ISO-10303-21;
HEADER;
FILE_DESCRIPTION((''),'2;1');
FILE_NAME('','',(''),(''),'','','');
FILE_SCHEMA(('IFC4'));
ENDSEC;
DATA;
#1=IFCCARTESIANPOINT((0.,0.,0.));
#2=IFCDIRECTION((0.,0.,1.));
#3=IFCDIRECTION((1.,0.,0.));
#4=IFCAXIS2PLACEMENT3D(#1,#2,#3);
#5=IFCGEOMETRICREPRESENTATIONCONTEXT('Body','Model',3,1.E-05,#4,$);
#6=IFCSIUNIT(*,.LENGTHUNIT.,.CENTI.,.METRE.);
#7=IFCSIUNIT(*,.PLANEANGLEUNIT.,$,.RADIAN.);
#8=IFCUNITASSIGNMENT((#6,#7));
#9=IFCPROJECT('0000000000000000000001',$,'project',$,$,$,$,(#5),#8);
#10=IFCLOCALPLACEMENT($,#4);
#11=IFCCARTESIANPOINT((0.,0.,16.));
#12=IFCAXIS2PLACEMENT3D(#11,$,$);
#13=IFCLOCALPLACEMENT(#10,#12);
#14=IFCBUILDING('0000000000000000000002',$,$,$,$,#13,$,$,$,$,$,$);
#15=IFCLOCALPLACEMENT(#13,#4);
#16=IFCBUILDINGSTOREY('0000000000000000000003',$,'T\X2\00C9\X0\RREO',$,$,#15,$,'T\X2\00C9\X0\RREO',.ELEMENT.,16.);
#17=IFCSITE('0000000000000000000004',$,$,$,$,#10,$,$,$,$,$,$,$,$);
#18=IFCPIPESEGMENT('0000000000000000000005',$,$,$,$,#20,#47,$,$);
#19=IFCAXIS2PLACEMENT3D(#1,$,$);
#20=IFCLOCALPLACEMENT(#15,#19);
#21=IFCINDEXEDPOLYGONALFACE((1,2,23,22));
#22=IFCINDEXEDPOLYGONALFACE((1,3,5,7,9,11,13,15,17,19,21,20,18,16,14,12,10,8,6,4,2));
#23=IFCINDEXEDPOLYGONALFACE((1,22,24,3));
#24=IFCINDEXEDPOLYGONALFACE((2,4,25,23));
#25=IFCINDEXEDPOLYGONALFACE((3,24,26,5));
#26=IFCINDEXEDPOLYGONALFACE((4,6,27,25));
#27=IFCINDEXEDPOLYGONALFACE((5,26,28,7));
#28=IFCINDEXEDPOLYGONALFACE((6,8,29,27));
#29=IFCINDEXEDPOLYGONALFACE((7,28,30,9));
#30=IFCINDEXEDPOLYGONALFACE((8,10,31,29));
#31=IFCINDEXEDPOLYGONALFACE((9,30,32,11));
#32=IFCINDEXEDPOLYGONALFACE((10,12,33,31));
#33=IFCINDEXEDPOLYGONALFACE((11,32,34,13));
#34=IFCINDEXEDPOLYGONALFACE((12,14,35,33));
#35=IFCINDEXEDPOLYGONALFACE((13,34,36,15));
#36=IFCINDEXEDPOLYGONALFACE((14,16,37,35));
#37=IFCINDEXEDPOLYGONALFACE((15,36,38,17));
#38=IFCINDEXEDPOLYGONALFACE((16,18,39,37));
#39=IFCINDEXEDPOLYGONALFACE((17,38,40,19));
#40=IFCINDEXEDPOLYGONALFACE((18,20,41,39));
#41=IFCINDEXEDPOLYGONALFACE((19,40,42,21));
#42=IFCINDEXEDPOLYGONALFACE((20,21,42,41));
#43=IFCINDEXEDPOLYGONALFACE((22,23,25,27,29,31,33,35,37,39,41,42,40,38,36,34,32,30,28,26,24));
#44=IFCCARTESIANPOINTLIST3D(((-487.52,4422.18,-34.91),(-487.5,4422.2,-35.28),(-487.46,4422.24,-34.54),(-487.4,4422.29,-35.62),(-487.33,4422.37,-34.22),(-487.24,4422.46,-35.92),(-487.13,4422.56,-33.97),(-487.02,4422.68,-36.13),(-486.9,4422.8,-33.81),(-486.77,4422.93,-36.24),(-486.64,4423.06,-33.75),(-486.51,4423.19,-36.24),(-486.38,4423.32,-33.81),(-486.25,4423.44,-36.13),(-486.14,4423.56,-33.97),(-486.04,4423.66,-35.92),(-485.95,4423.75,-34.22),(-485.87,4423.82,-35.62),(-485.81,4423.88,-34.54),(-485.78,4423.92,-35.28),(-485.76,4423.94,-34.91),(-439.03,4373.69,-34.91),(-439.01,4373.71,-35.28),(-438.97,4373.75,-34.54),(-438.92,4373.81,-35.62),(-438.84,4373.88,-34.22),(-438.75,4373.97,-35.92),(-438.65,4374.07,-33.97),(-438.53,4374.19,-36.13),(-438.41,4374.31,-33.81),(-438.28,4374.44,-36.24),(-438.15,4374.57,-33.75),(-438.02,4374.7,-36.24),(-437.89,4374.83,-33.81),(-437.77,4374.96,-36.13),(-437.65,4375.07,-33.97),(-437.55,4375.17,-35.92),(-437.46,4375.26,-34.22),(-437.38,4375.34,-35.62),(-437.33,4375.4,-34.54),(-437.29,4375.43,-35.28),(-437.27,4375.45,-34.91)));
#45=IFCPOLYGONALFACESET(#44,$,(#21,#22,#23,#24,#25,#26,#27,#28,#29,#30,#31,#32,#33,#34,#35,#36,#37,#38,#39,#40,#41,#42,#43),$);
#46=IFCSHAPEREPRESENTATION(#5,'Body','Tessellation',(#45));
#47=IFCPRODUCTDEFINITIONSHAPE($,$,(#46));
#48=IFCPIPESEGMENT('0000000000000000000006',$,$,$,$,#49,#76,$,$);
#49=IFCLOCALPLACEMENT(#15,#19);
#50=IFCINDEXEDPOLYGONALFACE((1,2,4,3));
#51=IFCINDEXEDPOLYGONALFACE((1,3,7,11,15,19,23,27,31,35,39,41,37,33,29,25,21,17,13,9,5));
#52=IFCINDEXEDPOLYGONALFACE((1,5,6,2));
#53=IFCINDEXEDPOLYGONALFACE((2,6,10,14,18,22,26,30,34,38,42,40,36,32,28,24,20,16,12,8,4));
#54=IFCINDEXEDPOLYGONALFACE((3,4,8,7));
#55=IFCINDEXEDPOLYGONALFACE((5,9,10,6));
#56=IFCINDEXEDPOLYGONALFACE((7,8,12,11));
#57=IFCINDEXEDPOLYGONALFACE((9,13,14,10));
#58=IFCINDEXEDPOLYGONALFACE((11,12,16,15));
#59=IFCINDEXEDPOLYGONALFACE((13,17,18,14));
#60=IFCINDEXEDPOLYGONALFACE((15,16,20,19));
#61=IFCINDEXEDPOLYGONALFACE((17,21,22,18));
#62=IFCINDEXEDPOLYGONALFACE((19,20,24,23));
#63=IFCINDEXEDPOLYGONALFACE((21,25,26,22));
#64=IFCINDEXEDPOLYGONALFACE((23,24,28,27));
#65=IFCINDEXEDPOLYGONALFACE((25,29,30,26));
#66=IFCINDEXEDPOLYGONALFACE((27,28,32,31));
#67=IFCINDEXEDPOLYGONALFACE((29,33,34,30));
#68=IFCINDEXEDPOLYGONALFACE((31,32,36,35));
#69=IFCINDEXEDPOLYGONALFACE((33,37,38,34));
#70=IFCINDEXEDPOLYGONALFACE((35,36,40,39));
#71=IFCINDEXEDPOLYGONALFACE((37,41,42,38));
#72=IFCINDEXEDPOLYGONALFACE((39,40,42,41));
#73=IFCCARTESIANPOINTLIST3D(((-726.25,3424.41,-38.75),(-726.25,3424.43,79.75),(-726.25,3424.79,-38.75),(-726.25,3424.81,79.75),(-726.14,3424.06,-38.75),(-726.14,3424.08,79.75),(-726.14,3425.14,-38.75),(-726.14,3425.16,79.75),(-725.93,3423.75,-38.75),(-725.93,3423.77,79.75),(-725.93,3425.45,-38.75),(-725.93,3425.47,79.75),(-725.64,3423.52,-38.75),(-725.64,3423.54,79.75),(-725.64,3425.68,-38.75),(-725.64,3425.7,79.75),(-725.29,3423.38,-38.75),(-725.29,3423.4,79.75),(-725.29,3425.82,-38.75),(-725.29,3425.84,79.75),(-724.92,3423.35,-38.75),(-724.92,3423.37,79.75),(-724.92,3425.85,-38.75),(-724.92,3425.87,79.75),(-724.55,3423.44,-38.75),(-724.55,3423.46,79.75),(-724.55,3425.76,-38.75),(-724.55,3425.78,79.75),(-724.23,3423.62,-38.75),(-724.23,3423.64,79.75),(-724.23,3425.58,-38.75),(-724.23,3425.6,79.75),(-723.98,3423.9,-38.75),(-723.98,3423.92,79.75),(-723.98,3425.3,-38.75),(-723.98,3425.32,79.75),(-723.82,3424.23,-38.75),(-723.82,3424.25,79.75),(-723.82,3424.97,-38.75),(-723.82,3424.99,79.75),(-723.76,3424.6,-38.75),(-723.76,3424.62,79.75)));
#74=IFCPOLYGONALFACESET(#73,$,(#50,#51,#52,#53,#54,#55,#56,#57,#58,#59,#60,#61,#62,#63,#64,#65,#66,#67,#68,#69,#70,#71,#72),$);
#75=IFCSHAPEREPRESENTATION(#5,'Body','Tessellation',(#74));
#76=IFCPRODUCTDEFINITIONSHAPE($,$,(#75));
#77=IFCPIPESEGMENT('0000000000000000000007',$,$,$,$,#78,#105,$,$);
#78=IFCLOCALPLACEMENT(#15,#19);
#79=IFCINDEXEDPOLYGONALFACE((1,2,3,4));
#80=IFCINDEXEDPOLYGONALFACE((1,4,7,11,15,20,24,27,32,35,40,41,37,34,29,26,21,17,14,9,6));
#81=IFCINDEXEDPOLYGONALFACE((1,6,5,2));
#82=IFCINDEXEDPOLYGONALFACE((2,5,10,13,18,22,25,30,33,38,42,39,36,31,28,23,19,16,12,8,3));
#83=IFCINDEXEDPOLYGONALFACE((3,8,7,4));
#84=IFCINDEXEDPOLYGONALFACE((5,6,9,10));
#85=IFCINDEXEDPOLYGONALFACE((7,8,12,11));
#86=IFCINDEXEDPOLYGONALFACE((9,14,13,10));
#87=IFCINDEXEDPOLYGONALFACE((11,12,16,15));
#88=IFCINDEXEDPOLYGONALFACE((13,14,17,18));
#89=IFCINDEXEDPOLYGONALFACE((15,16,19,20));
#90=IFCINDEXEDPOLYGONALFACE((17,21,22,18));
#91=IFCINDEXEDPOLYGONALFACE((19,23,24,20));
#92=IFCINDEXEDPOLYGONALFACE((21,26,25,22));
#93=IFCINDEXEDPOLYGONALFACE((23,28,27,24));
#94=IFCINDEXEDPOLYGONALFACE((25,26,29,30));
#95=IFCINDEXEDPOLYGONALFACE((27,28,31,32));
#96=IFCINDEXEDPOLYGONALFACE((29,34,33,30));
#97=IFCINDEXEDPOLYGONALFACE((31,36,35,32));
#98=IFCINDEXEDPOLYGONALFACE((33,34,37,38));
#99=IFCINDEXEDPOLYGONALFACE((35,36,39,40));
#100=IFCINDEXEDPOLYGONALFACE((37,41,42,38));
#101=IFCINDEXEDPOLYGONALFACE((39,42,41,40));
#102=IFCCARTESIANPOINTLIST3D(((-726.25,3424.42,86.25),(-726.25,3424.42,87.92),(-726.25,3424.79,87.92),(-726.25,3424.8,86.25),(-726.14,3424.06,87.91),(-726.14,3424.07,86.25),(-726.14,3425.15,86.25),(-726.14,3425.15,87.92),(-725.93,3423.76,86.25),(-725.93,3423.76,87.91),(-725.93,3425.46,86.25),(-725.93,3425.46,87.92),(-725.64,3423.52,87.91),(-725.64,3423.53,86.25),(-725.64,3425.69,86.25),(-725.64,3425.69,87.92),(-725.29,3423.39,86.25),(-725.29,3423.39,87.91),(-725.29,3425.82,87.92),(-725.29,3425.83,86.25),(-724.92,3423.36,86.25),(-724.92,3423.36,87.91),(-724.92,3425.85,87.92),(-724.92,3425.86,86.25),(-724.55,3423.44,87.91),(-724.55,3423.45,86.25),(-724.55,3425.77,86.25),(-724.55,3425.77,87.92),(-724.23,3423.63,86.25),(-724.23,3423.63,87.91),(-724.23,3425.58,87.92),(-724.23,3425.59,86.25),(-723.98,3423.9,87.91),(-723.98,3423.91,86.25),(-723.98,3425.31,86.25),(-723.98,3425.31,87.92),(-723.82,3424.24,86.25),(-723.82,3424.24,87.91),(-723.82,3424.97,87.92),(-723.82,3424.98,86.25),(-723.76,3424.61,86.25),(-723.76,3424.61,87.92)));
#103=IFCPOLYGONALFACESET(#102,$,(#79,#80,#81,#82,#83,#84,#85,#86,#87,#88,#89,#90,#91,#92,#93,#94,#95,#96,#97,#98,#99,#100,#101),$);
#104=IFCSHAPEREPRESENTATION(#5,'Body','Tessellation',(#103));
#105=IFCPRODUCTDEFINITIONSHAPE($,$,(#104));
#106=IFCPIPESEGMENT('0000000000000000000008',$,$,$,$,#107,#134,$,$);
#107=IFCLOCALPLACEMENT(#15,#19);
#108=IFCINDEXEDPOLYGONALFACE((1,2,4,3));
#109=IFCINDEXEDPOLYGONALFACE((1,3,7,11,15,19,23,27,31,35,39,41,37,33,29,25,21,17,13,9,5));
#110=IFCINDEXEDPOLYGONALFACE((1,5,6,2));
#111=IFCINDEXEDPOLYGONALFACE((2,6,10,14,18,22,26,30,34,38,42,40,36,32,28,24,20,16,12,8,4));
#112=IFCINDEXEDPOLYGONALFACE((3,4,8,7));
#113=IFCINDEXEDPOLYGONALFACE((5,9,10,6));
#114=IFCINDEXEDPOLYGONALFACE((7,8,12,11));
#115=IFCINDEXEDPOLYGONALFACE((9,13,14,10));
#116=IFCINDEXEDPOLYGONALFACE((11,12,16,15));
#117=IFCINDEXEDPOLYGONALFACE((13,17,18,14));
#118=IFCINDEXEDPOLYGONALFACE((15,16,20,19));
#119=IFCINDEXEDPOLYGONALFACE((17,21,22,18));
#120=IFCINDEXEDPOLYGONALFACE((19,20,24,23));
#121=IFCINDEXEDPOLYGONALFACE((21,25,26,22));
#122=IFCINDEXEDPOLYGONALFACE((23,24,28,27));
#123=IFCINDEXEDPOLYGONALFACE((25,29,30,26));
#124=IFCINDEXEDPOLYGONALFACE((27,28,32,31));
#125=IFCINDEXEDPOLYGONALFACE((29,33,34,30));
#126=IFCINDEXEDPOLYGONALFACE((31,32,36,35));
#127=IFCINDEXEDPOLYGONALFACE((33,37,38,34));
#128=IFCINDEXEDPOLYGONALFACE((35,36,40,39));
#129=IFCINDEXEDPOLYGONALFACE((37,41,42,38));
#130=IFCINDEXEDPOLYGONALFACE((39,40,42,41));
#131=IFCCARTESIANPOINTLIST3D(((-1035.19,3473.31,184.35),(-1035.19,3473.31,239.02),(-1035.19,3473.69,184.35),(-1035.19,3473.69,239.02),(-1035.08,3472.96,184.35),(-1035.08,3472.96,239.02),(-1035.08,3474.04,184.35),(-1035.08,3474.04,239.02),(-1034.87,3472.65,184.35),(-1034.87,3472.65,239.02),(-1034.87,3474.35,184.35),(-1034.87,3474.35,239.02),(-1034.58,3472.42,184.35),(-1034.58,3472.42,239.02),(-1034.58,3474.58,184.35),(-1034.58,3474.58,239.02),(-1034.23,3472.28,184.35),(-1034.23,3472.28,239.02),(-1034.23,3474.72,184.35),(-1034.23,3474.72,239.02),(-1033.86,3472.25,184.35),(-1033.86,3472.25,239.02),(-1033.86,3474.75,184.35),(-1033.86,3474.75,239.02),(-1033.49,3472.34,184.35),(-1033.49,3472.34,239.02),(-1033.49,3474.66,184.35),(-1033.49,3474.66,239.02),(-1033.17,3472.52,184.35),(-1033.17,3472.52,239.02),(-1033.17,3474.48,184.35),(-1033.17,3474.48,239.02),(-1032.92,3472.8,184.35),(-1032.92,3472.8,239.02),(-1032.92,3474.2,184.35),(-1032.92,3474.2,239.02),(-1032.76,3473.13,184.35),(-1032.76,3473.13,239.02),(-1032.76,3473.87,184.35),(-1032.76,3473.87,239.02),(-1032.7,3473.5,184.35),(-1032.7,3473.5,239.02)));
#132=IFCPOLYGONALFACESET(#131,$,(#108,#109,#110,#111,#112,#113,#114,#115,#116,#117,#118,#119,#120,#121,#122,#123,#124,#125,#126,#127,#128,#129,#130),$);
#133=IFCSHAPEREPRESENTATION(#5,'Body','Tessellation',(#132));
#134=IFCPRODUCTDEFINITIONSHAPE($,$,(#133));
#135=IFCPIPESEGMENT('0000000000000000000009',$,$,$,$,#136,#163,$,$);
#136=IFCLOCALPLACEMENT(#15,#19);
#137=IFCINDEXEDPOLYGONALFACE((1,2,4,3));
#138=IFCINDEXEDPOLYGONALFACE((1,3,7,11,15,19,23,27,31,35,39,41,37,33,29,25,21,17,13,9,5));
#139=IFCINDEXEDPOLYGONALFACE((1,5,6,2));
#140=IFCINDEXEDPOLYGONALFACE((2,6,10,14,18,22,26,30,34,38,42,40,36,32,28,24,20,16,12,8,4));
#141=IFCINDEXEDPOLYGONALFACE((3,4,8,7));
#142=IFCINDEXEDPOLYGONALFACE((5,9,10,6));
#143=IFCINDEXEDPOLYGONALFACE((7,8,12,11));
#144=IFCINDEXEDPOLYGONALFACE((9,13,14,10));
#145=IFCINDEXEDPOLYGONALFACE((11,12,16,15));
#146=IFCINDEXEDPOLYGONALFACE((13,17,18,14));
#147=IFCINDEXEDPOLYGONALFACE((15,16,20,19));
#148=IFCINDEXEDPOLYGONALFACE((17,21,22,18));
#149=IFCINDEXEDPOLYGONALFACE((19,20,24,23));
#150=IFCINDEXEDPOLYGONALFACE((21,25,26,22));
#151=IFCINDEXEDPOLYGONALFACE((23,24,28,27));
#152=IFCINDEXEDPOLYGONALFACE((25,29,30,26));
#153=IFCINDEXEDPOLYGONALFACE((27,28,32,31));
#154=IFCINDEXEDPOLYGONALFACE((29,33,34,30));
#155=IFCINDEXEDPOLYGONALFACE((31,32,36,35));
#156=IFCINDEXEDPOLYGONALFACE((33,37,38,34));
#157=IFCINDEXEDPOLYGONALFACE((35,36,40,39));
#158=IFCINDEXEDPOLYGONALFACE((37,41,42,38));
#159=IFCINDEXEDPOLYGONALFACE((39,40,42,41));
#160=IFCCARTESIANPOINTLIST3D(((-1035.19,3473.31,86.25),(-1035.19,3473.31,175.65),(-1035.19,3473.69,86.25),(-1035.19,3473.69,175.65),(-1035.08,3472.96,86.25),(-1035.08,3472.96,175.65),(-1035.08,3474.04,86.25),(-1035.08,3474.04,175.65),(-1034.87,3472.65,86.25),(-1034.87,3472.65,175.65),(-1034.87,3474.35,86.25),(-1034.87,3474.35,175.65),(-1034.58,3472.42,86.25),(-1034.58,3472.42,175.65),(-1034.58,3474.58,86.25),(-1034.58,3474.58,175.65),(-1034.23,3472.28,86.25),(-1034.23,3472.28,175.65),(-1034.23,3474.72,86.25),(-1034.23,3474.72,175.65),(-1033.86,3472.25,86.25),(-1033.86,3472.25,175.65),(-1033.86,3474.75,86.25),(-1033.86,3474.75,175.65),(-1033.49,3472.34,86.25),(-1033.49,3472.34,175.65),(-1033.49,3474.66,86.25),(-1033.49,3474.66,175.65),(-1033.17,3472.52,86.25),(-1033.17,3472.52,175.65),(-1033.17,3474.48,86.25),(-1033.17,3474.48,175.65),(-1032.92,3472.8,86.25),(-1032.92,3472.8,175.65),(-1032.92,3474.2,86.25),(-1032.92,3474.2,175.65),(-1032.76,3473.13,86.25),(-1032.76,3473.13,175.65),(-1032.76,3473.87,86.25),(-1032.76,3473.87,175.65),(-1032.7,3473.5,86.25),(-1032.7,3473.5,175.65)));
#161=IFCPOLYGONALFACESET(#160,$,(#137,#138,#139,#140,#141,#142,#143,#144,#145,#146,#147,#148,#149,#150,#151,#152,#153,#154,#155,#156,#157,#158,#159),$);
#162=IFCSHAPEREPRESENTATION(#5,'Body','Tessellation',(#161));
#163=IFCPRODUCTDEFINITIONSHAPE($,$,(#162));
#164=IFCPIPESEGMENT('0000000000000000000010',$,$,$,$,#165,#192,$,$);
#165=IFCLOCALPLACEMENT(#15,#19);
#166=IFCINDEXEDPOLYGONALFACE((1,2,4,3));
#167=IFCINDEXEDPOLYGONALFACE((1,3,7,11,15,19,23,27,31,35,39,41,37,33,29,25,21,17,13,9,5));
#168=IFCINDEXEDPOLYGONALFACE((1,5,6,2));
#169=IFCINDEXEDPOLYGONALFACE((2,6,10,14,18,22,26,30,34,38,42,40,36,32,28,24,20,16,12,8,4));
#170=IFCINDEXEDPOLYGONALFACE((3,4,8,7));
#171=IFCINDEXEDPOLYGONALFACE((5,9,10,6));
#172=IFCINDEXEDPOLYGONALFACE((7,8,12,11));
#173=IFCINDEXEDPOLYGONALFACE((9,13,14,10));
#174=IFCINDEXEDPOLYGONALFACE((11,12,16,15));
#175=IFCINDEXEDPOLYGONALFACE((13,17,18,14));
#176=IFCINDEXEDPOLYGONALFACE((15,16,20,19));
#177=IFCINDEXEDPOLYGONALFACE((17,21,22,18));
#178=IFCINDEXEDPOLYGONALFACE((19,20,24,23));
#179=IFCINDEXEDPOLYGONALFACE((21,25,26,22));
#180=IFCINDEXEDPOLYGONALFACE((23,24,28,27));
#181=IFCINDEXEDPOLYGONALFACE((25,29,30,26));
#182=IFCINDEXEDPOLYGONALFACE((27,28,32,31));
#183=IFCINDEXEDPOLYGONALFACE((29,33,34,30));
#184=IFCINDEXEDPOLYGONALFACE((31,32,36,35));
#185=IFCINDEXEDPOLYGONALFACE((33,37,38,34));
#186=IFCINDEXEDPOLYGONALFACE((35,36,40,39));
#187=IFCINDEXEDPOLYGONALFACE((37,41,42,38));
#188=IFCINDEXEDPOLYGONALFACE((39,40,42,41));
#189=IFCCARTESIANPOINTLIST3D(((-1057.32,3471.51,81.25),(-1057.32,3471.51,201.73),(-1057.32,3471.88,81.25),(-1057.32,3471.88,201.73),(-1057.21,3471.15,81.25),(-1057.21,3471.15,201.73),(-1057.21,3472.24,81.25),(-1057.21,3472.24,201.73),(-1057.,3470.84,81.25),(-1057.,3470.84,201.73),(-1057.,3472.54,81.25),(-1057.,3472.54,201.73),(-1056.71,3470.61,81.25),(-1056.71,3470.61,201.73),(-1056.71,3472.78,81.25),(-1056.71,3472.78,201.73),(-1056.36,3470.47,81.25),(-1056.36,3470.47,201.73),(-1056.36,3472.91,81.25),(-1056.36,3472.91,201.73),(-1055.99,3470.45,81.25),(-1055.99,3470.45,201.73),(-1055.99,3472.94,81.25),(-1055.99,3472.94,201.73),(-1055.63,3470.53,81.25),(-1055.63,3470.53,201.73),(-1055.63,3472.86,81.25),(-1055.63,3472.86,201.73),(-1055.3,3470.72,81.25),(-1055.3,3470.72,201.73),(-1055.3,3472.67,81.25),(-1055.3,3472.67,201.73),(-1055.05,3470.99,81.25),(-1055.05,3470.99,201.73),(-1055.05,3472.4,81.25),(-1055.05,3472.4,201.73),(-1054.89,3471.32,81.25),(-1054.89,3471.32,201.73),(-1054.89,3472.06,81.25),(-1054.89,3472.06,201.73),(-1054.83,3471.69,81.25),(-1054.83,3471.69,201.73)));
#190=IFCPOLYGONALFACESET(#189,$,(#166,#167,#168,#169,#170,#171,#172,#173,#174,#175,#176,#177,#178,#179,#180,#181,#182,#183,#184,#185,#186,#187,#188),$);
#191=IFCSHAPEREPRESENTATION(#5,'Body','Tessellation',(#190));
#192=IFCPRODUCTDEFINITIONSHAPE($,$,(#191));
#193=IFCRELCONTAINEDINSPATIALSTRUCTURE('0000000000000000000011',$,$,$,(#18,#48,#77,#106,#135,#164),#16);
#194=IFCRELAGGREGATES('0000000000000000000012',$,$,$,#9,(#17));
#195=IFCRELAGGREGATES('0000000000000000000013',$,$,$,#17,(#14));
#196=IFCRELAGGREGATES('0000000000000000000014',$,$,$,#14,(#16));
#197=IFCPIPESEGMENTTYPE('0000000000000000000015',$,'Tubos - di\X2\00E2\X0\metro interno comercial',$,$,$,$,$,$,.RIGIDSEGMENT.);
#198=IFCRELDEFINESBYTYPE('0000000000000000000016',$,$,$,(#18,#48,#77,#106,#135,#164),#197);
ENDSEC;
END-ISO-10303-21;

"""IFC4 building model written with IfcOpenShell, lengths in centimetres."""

from ifc_helpers import new_model, si_unit, frame, origin_with_axes, origin_2d_with_axis, place, context, project, spatial, circle, extrude, type_object, element, save


model = new_model("IFC4")

# Units and contexts
model_context = context("Model", 3, precision=1e-05, world=origin_with_axes(), identifier="Body")
ifc_project = project(units=[si_unit("LENGTHUNIT", "METRE", prefix="CENTI"), si_unit("PLANEANGLEUNIT", "RADIAN")], contexts=[model_context])

# Site, building, storey
site_placement = place(None, origin_with_axes())
site = spatial("IfcSite", under=ifc_project, at=site_placement)
building_placement = place(site_placement, frame((0.0, 0.0, 16.0)))
building = spatial("IfcBuilding", under=site, at=building_placement)
storey_placement = place(building_placement, origin_with_axes())
storey = spatial("IfcBuildingStorey", under=building, at=storey_placement, Name="TÉRREO", LongName="TÉRREO", CompositionType="ELEMENT", Elevation=16.0)

# Pipe segments
pipe_segment_type = type_object("IfcPipeSegmentType", Name="Tubos - diâmetro interno comercial", PredefinedType="RIGIDSEGMENT")
pipe_segment_1_placement = place(storey_placement, frame((-462.39, 4398.82, -33.75), z_axis=(0.0, 0.0, 1.0), x_axis=(1.0, 0.0, 0.0)))
element("IfcPipeSegment", 1, at=pipe_segment_1_placement, inside=storey, type_object=pipe_segment_type, context=model_context, shape_type="SolidModel", body=[
    extrude(circle(Radius=1.25, at=origin_2d_with_axis()), frame((24.24, -24.24, -1.25), z_axis=(-0.707107, 0.707107, 0.0), x_axis=(0.0, 0.0, 1.0)), (0.0, 0.0, 1.0), 68.57),
])
pipe_segment_2_placement = place(storey_placement, frame((-725.01, 3424.61, 79.75), z_axis=(0.0, 0.0, 1.0), x_axis=(1.0, 0.0, 0.0)))
element("IfcPipeSegment", 2, at=pipe_segment_2_placement, inside=storey, type_object=pipe_segment_type, context=model_context, shape_type="SolidModel", body=[
    extrude(circle(Radius=1.25, at=origin_2d_with_axis()), frame((0.0, 0.01, 0.0), z_axis=(0.0, -0.000163, -1.0), x_axis=(1.0, 0.0, 0.0)), (0.0, 0.0, 1.0), 118.5),
])
pipe_segment_3_placement = place(storey_placement, frame((-725.01, 3424.61, 87.92), z_axis=(0.0, 0.0, 1.0), x_axis=(1.0, 0.0, 0.0)))
element("IfcPipeSegment", 3, at=pipe_segment_3_placement, inside=storey, type_object=pipe_segment_type, context=model_context, shape_type="SolidModel", body=[
    extrude(circle(Radius=1.25, at=origin_2d_with_axis()), frame((0.0, 0.0, 0.0), z_axis=(0.0, 0.002913, -1.0), x_axis=(1.0, 0.0, 0.0)), (0.0, 0.0, 1.0), 1.67),
])
pipe_segment_4_placement = place(storey_placement, frame((-1033.95, 3473.5, 239.02), z_axis=(0.0, 0.0, 1.0), x_axis=(1.0, 0.0, 0.0)))
element("IfcPipeSegment", 4, at=pipe_segment_4_placement, inside=storey, type_object=pipe_segment_type, context=model_context, shape_type="SolidModel", body=[
    extrude(circle(Radius=1.25, at=origin_2d_with_axis()), frame((0.0, 0.0, 0.0), z_axis=(0.0, 0.0, -1.0), x_axis=(1.0, 0.0, 0.0)), (0.0, 0.0, 1.0), 54.67),
])
pipe_segment_5_placement = place(storey_placement, frame((-1033.95, 3473.5, 175.65), z_axis=(0.0, 0.0, 1.0), x_axis=(1.0, 0.0, 0.0)))
element("IfcPipeSegment", 5, at=pipe_segment_5_placement, inside=storey, type_object=pipe_segment_type, context=model_context, shape_type="SolidModel", body=[
    extrude(circle(Radius=1.25, at=origin_2d_with_axis()), frame((0.0, 0.0, 0.0), z_axis=(0.0, 0.0, -1.0), x_axis=(1.0, 0.0, 0.0)), (0.0, 0.0, 1.0), 89.4),
])
pipe_segment_6_placement = place(storey_placement, frame((-1056.08, 3471.69, 201.73), z_axis=(0.0, 0.0, 1.0), x_axis=(1.0, 0.0, 0.0)))
element("IfcPipeSegment", 6, at=pipe_segment_6_placement, inside=storey, type_object=pipe_segment_type, context=model_context, shape_type="SolidModel", body=[
    extrude(circle(Radius=1.25, at=origin_2d_with_axis()), frame((0.0, 0.0, -120.48), z_axis=(0.0, 0.0, 1.0), x_axis=(1.0, 0.0, 0.0)), (0.0, 0.0, 1.0), 120.48),
])

save(model, "model.ifc")
